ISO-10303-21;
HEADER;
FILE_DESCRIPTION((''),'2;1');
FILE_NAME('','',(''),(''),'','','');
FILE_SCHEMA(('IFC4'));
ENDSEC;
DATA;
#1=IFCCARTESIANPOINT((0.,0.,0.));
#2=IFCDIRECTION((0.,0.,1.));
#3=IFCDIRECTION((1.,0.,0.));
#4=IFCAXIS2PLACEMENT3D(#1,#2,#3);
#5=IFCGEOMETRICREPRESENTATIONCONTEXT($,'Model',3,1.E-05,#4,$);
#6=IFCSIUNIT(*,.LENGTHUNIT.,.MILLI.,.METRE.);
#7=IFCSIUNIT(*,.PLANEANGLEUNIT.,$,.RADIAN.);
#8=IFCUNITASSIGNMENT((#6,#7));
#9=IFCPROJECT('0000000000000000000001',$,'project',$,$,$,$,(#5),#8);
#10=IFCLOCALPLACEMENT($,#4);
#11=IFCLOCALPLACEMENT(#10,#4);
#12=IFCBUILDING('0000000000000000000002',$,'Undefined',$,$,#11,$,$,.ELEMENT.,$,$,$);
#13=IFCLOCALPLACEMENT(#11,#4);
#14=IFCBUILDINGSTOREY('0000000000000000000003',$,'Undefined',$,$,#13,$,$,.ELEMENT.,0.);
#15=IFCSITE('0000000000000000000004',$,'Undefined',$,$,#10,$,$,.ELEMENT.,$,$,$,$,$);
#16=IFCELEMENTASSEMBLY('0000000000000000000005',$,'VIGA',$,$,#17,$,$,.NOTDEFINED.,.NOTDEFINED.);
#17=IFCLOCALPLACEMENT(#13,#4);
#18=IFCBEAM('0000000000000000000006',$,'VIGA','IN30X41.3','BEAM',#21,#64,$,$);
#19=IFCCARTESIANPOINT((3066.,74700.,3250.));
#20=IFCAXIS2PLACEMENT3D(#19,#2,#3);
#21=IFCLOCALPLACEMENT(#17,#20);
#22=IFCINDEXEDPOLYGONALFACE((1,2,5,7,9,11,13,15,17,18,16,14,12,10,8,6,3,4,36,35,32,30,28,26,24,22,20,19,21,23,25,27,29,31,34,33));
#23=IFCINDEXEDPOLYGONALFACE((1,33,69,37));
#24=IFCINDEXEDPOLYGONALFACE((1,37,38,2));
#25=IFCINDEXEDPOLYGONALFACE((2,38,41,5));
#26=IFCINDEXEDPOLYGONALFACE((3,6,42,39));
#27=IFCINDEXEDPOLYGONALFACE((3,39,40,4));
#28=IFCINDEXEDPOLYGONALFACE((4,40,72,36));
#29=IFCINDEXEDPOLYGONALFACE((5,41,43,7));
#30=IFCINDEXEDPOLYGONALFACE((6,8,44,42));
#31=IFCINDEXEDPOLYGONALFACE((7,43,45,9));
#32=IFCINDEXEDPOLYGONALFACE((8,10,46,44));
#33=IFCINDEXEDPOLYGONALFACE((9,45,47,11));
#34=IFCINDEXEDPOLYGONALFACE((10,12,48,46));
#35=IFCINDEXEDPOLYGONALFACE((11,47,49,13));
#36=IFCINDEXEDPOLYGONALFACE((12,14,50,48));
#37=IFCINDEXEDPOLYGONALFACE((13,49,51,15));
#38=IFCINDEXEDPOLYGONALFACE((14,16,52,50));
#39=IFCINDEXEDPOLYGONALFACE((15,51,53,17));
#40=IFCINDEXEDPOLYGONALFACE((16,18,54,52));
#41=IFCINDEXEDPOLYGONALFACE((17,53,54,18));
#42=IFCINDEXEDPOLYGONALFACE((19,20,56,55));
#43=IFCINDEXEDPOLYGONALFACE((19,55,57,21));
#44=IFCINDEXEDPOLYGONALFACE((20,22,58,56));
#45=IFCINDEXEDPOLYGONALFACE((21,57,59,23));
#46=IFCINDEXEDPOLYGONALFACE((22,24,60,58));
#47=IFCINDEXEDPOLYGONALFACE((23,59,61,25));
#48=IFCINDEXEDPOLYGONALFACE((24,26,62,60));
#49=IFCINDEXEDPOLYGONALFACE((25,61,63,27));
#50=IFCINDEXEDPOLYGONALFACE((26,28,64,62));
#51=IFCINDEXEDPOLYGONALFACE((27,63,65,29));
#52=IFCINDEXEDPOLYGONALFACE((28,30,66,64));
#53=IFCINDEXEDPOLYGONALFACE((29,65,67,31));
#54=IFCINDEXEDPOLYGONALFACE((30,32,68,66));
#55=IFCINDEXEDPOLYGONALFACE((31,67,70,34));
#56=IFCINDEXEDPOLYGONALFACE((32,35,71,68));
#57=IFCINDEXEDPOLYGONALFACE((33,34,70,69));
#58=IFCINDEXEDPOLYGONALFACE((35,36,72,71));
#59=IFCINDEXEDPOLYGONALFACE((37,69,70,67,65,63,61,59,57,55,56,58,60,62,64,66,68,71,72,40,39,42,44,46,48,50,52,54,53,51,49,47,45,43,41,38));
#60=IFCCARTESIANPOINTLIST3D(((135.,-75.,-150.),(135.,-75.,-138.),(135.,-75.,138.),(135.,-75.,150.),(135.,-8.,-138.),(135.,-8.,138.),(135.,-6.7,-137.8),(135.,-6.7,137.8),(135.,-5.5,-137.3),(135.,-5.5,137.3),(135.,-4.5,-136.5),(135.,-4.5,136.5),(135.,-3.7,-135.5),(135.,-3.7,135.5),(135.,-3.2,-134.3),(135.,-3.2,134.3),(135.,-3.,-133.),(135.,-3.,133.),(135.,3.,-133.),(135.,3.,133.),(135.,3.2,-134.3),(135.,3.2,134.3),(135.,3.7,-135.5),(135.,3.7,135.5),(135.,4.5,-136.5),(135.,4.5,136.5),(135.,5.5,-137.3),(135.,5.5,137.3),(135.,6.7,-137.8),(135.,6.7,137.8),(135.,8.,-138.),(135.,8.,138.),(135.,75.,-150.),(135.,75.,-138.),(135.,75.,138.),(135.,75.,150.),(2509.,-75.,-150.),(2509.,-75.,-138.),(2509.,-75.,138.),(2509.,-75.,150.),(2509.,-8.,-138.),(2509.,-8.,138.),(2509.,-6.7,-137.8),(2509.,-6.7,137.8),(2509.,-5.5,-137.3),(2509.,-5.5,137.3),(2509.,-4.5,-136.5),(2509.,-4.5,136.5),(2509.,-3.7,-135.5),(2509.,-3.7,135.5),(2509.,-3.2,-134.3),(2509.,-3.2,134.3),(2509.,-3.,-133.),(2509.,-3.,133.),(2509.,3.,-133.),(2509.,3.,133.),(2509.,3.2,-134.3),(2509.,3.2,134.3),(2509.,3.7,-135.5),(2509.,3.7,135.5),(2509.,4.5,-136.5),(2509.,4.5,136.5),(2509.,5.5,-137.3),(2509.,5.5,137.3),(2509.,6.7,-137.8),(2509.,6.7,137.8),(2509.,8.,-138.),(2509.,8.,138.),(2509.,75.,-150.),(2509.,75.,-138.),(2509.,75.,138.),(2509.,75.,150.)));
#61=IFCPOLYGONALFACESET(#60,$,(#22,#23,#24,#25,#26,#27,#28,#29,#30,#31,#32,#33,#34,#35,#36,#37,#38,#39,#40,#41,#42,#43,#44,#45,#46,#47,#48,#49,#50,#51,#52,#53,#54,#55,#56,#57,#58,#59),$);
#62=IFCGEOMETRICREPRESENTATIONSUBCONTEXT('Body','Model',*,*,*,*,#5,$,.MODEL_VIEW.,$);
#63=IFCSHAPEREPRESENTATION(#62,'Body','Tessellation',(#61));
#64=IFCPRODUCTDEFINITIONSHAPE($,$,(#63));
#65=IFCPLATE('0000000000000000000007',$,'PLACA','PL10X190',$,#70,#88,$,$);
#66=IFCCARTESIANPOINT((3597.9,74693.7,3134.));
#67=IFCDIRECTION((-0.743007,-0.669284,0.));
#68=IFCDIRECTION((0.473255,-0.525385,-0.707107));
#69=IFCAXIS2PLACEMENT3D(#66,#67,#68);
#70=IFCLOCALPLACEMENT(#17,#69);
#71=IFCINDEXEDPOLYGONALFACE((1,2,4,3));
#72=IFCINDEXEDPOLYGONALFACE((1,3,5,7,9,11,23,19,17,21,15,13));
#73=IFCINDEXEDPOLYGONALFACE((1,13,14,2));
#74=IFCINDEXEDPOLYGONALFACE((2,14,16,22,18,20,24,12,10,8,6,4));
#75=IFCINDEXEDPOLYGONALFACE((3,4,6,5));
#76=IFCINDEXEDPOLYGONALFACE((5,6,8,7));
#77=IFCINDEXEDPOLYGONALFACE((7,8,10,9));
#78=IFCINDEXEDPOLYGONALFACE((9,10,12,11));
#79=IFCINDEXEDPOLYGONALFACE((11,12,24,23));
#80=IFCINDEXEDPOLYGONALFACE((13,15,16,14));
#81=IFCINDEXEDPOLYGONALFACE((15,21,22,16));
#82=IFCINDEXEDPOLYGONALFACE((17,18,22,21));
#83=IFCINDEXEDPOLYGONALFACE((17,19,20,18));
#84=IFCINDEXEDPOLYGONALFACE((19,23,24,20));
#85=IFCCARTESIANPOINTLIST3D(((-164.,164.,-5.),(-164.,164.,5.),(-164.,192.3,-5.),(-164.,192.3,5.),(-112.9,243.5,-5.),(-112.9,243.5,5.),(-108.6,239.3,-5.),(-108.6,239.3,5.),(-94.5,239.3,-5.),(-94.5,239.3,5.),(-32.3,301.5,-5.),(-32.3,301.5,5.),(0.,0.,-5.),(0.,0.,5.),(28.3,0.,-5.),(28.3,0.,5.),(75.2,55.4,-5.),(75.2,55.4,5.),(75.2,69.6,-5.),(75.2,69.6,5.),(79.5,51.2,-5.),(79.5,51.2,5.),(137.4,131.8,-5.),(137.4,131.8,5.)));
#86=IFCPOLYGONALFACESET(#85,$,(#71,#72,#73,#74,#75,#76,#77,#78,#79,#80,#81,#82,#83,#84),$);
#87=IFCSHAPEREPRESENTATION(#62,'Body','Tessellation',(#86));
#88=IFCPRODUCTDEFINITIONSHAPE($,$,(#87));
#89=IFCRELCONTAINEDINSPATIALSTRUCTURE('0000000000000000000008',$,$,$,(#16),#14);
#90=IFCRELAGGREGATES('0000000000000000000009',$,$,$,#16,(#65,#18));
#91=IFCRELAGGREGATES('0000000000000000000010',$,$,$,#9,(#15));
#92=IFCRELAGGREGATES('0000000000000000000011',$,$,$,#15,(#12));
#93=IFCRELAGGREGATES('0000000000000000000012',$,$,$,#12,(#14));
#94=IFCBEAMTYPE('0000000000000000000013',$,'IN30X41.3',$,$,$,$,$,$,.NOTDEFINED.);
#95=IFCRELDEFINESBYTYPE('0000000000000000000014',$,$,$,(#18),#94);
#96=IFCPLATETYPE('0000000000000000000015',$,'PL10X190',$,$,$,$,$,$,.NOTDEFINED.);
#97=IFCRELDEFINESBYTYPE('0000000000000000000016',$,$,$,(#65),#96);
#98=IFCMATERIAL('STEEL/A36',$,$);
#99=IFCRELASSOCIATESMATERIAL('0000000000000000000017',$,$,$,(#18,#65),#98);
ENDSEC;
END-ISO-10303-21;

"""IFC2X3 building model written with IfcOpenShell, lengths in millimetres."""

from ifc_helpers import new_model, si_unit, frame, origin_with_axes, origin_2d_with_axis, place, context, subcontext, project, spatial, polyline, i_section, outline, extrude, clip, halfspace, material, type_object, element, aggregate, save


model = new_model("IFC2X3")

# Units and contexts
model_context = context("Model", 3, precision=1e-05, world=origin_with_axes())
body_context = subcontext(model_context, "Body", "Model", "MODEL_VIEW")
ifc_project = project(units=[si_unit("LENGTHUNIT", "METRE", prefix="MILLI"), si_unit("PLANEANGLEUNIT", "RADIAN")], contexts=[model_context])

# Site, building, storey
site_placement = place(None, origin_with_axes())
site = spatial("IfcSite", under=ifc_project, at=site_placement, Name="Undefined", CompositionType="ELEMENT")
building_placement = place(site_placement, origin_with_axes())
building = spatial("IfcBuilding", under=site, at=building_placement, Name="Undefined", CompositionType="ELEMENT")
storey_placement = place(building_placement, origin_with_axes())
storey = spatial("IfcBuildingStorey", under=building, at=storey_placement, Name="Undefined", CompositionType="ELEMENT", Elevation=0.0)

# Shared definitions
ifc_material_1 = material(Name="STEEL/A36")

# Element assembly, beam
assembly_1_placement = place(storey_placement, origin_with_axes())
assembly_1 = element("IfcElementAssembly", 1, at=assembly_1_placement, inside=storey, Name="VIGA", AssemblyPlace="NOTDEFINED", PredefinedType="NOTDEFINED")
beam_type_1 = type_object("IfcBeamType", Name="IN30X41.3", PredefinedType="NOTDEFINED")
beam_1_placement = place(assembly_1_placement, frame((3066.0, 74700.0, 3250.0), z_axis=(0.0, 0.0, 1.0), x_axis=(1.0, 0.0, 0.0)))
beam_1 = element("IfcBeam", 2, at=beam_1_placement, type_object=beam_type_1, material=ifc_material_1, Name="VIGA", Description="IN30X41.3", ObjectType="BEAM", context=body_context, shape_type="Clipping", body=[
    clip(clip(extrude(i_section(OverallWidth=150.0, OverallDepth=300.0, WebThickness=6.0, FlangeThickness=12.0, FilletRadius=5.0, at=origin_2d_with_axis()), frame((2644.0, 0.0, 0.0), z_axis=(-1.0, 0.0, 0.0), x_axis=(0.0, -1.0, 0.0)), (0.0, 0.0, 1.0), 2644.0), halfspace(frame((2509.0, 0.0, 250.0), z_axis=(1.0, 0.0, 0.0), x_axis=(0.0, 1.0, 0.0)), False)), halfspace(frame((135.0, 0.0, 250.0), z_axis=(-1.0, 0.0, 0.0), x_axis=(0.0, -1.0, 0.0)), False)),
])

# Plate
plate_type_1 = type_object("IfcPlateType", Name="PL10X190", PredefinedType="NOTDEFINED")
plate_1_placement = place(assembly_1_placement, frame((3597.9, 74693.7, 3134.0), z_axis=(-0.743007, -0.669284, 0.0), x_axis=(0.473255, -0.525385, -0.707107)))
plate_1 = element("IfcPlate", 3, at=plate_1_placement, type_object=plate_type_1, material=ifc_material_1, Name="PLACA", Description="PL10X190", context=body_context, shape_type="SweptSolid", body=[
    extrude(outline(polyline([(0.0, 0.0), (28.3, 0.0), (79.5, 51.2), (75.2, 55.4), (75.2, 69.6), (137.4, 131.8), (-32.3, 301.5), (-94.5, 239.3), (-108.6, 239.3), (-112.9, 243.5), (-164.0, 192.3), (-164.0, 164.0), (0.0, 0.0)])), frame((0.0, 0.0, -5.0), z_axis=(0.0, 0.0, 1.0), x_axis=(1.0, 0.0, 0.0)), (0.0, 0.0, 1.0), 10.0),
])
aggregate(assembly_1, [plate_1, beam_1])

save(model, "model.ifc")
